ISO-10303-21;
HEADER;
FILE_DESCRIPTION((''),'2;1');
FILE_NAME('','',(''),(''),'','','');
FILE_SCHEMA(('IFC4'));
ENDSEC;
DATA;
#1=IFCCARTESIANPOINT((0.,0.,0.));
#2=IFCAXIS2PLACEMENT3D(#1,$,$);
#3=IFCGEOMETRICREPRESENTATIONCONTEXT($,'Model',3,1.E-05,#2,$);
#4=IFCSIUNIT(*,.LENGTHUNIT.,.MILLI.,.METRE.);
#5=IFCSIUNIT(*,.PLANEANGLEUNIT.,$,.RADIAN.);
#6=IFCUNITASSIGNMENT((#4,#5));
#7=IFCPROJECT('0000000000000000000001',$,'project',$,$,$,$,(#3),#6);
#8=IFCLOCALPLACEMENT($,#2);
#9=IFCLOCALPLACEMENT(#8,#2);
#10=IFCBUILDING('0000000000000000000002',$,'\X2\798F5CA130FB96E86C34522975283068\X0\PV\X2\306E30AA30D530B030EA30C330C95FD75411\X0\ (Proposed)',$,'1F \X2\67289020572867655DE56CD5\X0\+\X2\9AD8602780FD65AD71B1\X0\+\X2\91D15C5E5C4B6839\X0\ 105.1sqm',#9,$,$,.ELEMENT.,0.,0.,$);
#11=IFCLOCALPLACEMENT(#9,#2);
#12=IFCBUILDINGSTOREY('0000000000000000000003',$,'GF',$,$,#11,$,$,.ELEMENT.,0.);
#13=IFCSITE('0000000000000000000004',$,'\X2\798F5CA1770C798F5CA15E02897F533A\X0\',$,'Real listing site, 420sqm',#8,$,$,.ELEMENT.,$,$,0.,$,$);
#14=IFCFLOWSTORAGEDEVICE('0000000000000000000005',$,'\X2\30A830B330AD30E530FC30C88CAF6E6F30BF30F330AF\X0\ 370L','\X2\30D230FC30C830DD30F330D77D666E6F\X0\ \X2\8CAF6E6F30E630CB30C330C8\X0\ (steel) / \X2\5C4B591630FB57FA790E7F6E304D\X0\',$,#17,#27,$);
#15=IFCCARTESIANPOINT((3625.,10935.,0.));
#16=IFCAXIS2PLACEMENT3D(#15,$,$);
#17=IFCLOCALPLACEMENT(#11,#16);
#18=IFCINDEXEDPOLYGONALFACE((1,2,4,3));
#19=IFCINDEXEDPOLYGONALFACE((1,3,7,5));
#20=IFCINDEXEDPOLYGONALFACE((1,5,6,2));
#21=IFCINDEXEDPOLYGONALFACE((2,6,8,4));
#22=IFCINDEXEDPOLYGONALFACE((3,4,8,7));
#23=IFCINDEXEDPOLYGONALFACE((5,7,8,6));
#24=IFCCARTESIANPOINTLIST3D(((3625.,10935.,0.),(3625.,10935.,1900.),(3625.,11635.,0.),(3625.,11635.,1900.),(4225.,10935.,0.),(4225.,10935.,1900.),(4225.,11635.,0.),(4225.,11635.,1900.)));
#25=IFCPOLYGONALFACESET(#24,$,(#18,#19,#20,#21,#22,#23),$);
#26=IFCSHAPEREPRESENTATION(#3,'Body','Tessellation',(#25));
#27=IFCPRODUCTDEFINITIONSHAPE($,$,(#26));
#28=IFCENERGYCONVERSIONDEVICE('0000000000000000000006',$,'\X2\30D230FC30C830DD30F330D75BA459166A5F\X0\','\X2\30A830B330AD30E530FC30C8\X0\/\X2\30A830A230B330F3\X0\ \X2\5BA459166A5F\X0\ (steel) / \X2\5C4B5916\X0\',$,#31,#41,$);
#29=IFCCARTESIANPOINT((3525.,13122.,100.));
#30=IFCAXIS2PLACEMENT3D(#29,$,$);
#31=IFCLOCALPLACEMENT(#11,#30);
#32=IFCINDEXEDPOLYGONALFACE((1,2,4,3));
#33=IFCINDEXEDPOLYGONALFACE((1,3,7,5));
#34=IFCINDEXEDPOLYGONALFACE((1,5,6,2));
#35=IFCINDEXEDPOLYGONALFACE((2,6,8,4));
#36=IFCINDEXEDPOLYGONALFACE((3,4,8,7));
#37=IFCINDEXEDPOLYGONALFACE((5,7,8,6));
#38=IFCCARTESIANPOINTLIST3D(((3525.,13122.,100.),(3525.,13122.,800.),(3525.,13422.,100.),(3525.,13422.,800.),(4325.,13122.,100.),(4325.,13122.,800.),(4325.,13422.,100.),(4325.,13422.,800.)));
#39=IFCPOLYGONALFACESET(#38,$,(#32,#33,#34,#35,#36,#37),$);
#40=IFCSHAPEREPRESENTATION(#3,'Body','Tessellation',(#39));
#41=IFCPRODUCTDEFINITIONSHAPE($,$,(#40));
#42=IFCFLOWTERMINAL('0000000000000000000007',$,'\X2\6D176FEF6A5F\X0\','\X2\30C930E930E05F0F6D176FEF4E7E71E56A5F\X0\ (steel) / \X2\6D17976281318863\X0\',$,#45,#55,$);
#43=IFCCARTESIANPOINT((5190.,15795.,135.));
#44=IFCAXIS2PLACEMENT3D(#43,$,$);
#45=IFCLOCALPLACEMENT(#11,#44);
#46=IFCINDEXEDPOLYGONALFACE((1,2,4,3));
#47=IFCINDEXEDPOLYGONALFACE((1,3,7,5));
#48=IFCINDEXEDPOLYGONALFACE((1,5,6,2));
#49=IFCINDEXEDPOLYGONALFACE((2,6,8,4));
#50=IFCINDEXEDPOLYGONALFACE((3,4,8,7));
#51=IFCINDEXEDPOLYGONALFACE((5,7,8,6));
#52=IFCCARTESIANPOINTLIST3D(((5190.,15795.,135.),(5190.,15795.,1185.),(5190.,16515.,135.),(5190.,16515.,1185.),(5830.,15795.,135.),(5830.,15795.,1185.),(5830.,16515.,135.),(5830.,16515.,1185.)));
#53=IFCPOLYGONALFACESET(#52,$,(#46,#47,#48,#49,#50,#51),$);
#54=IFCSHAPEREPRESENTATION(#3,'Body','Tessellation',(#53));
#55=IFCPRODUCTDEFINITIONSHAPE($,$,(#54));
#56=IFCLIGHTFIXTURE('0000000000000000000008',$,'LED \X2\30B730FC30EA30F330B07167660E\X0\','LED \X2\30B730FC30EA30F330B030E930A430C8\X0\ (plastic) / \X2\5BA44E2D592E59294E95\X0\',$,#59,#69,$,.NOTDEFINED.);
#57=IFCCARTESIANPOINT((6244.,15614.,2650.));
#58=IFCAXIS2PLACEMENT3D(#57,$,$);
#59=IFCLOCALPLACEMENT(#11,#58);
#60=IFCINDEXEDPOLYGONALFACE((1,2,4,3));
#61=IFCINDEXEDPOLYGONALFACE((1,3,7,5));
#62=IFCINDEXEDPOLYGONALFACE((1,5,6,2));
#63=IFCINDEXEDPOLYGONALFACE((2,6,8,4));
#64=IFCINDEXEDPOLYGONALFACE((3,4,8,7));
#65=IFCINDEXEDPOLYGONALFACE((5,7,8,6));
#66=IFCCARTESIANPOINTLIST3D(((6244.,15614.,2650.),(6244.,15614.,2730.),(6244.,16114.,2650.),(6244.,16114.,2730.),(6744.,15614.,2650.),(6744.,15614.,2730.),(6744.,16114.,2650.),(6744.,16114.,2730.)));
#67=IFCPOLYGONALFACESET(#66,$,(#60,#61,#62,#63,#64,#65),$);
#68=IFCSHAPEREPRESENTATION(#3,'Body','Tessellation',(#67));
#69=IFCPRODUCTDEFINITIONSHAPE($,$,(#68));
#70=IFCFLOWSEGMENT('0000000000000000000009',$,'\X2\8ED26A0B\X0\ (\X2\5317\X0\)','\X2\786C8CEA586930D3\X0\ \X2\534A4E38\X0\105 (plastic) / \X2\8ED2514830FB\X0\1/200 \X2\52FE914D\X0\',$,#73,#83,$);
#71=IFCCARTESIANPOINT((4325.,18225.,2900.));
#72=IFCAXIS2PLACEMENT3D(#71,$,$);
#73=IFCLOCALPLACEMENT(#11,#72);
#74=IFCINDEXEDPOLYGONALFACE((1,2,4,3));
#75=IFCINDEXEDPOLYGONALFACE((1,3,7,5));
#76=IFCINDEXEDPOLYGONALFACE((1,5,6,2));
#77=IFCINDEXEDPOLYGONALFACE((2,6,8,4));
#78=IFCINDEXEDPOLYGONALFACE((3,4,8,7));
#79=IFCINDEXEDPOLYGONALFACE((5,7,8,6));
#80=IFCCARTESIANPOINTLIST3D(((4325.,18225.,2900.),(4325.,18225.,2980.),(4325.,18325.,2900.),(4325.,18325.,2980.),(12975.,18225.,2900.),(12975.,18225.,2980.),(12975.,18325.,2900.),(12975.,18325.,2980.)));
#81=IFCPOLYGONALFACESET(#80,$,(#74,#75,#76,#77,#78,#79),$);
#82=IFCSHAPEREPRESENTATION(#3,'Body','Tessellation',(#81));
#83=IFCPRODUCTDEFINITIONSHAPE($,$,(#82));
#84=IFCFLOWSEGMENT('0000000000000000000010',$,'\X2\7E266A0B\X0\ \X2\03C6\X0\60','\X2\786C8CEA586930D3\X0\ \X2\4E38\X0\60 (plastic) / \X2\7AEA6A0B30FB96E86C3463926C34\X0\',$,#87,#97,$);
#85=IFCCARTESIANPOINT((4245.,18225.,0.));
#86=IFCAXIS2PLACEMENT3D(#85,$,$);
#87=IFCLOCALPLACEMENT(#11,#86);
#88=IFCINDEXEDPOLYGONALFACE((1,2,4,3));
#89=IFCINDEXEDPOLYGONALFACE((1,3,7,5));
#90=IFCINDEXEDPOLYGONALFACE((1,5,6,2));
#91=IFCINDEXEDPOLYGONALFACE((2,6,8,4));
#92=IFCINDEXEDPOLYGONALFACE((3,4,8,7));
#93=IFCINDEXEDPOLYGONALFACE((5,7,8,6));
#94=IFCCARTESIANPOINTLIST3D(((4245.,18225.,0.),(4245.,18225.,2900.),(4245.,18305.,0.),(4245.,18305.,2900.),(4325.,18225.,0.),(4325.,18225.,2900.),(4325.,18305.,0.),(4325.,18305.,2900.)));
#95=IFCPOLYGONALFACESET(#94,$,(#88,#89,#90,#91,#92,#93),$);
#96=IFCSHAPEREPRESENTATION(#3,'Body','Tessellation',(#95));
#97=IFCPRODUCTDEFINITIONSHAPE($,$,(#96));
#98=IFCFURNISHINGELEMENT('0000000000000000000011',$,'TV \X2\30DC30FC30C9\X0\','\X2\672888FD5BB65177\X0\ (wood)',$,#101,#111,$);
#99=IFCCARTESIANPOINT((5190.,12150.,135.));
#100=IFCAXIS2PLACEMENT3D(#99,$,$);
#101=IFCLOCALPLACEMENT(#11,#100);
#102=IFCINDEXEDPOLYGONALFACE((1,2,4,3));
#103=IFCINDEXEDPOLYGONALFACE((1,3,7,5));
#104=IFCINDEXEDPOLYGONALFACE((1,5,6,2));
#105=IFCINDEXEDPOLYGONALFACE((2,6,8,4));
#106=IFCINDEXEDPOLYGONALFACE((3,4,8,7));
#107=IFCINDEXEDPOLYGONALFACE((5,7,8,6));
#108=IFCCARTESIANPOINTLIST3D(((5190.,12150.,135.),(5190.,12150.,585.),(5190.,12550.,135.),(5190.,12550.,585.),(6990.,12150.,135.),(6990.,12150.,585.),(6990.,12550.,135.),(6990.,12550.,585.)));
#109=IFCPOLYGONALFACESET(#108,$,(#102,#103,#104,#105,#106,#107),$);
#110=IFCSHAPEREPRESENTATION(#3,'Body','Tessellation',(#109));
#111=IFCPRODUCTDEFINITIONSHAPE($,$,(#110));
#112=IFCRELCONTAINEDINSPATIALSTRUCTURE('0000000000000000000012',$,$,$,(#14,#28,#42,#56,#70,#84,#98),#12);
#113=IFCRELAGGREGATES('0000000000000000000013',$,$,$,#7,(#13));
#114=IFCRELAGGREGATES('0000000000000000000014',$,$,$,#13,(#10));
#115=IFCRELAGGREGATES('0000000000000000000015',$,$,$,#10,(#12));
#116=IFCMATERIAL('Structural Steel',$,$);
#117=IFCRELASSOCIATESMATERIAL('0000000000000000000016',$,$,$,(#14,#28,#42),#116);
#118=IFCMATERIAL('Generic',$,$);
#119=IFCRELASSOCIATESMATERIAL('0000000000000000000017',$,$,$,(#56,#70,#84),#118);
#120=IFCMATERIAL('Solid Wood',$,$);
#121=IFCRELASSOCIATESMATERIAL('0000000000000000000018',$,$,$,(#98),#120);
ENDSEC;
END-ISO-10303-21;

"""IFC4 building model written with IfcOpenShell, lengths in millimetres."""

from ifc_helpers import new_model, si_unit, frame, frame_2d, origin, place, context, project, spatial, rectangle, extrude, material, element, save


model = new_model("IFC4")

# Units and contexts
model_context = context("Model", 3, precision=1e-05, world=origin())
ifc_project = project(units=[si_unit("LENGTHUNIT", "METRE", prefix="MILLI"), si_unit("PLANEANGLEUNIT", "RADIAN")], contexts=[model_context])

# Site, building, storey
site_placement = place(None, origin())
site = spatial("IfcSite", under=ifc_project, at=site_placement, Name="福岡県福岡市西区", ObjectType="Real listing site, 420sqm", CompositionType="ELEMENT", RefElevation=0.0)
building_placement = place(site_placement, origin())
building = spatial("IfcBuilding", under=site, at=building_placement, Name="福岡・雨水利用とPVのオフグリッド志向 (Proposed)", ObjectType="1F 木造在来工法+高性能断熱+金属屋根 105.1sqm", CompositionType="ELEMENT", ElevationOfRefHeight=0.0, ElevationOfTerrain=0.0)
storey_placement = place(building_placement, origin())
storey = spatial("IfcBuildingStorey", under=building, at=storey_placement, Name="GF", CompositionType="ELEMENT", Elevation=0.0)

# Shared definitions
ifc_material_1 = material(Name="Solid Wood")

# Shared definitions
ifc_material_2 = material(Name="Structural Steel")

# Shared definitions
ifc_material_3 = material(Name="Generic")

# Flow storage device
flow_storage_device_placement = place(storey_placement, frame((3625.0, 10935.0, 0.0)))
element("IfcFlowStorageDevice", 1, at=flow_storage_device_placement, inside=storey, material=ifc_material_2, Name="エコキュート貯湯タンク 370L", Description="ヒートポンプ給湯 貯湯ユニット (steel) / 屋外・基礎置き", context=model_context, shape_type="SweptSolid", body=[
    extrude(rectangle(XDim=600.0, YDim=700.0, at=frame_2d((300.0, 350.0))), frame((3625.0, 10935.0, 0.0)), (0.0, 0.0, 1.0), 1900.0),
])

# Energy conversion device
energy_conversion_device_placement = place(storey_placement, frame((3525.0, 13122.0, 100.0)))
element("IfcEnergyConversionDevice", 2, at=energy_conversion_device_placement, inside=storey, material=ifc_material_2, Name="ヒートポンプ室外機", Description="エコキュート/エアコン 室外機 (steel) / 屋外", context=model_context, shape_type="SweptSolid", body=[
    extrude(rectangle(XDim=800.0, YDim=300.0, at=frame_2d((400.0, 150.0))), frame((3525.0, 13122.0, 100.0)), (0.0, 0.0, 1.0), 700.0),
])

# Flow terminal
flow_terminal_placement = place(storey_placement, frame((5190.0, 15795.0, 135.0)))
element("IfcFlowTerminal", 3, at=flow_terminal_placement, inside=storey, material=ifc_material_2, Name="洗濯機", Description="ドラム式洗濯乾燥機 (steel) / 洗面脱衣", context=model_context, shape_type="SweptSolid", body=[
    extrude(rectangle(XDim=640.0, YDim=720.0, at=frame_2d((320.0, 360.0))), frame((5190.0, 15795.0, 135.0)), (0.0, 0.0, 1.0), 1050.0),
])

# Light fixture
light_fixture_placement = place(storey_placement, frame((6244.0, 15614.0, 2650.0)))
element("IfcLightFixture", 4, at=light_fixture_placement, inside=storey, material=ifc_material_3, Name="LED シーリング照明", Description="LED シーリングライト (plastic) / 室中央天井", PredefinedType="NOTDEFINED", context=model_context, shape_type="SweptSolid", body=[
    extrude(rectangle(XDim=500.0, YDim=500.0, at=frame_2d((250.0, 250.0))), frame((6244.0, 15614.0, 2650.0)), (0.0, 0.0, 1.0), 80.0),
])

# Flow segments
flow_segment_1_placement = place(storey_placement, frame((4325.0, 18225.0, 2900.0)))
element("IfcFlowSegment", 5, at=flow_segment_1_placement, inside=storey, material=ifc_material_3, Name="軒樋 (北)", Description="硬質塩ビ 半丸105 (plastic) / 軒先・1/200 勾配", context=model_context, shape_type="SweptSolid", body=[
    extrude(rectangle(XDim=8650.0, YDim=100.0, at=frame_2d((4325.0, 50.0))), frame((4325.0, 18225.0, 2900.0)), (0.0, 0.0, 1.0), 80.0),
])
flow_segment_2_placement = place(storey_placement, frame((4245.0, 18225.0, 0.0)))
element("IfcFlowSegment", 6, at=flow_segment_2_placement, inside=storey, material=ifc_material_3, Name="縦樋 φ60", Description="硬質塩ビ 丸60 (plastic) / 竪樋・雨水排水", context=model_context, shape_type="SweptSolid", body=[
    extrude(rectangle(XDim=80.0, YDim=80.0, at=frame_2d((40.0, 40.0))), frame((4245.0, 18225.0, 0.0)), (0.0, 0.0, 1.0), 2900.0),
])

# Furnishing element
furnishing_placement = place(storey_placement, frame((5190.0, 12150.0, 135.0)))
element("IfcFurnishingElement", 7, at=furnishing_placement, inside=storey, material=ifc_material_1, Name="TV ボード", Description="木製家具 (wood)", context=model_context, shape_type="SweptSolid", body=[
    extrude(rectangle(XDim=1800.0, YDim=400.0, at=frame_2d((900.0, 200.0))), frame((5190.0, 12150.0, 135.0)), (0.0, 0.0, 1.0), 450.0),
])

save(model, "model.ifc")
